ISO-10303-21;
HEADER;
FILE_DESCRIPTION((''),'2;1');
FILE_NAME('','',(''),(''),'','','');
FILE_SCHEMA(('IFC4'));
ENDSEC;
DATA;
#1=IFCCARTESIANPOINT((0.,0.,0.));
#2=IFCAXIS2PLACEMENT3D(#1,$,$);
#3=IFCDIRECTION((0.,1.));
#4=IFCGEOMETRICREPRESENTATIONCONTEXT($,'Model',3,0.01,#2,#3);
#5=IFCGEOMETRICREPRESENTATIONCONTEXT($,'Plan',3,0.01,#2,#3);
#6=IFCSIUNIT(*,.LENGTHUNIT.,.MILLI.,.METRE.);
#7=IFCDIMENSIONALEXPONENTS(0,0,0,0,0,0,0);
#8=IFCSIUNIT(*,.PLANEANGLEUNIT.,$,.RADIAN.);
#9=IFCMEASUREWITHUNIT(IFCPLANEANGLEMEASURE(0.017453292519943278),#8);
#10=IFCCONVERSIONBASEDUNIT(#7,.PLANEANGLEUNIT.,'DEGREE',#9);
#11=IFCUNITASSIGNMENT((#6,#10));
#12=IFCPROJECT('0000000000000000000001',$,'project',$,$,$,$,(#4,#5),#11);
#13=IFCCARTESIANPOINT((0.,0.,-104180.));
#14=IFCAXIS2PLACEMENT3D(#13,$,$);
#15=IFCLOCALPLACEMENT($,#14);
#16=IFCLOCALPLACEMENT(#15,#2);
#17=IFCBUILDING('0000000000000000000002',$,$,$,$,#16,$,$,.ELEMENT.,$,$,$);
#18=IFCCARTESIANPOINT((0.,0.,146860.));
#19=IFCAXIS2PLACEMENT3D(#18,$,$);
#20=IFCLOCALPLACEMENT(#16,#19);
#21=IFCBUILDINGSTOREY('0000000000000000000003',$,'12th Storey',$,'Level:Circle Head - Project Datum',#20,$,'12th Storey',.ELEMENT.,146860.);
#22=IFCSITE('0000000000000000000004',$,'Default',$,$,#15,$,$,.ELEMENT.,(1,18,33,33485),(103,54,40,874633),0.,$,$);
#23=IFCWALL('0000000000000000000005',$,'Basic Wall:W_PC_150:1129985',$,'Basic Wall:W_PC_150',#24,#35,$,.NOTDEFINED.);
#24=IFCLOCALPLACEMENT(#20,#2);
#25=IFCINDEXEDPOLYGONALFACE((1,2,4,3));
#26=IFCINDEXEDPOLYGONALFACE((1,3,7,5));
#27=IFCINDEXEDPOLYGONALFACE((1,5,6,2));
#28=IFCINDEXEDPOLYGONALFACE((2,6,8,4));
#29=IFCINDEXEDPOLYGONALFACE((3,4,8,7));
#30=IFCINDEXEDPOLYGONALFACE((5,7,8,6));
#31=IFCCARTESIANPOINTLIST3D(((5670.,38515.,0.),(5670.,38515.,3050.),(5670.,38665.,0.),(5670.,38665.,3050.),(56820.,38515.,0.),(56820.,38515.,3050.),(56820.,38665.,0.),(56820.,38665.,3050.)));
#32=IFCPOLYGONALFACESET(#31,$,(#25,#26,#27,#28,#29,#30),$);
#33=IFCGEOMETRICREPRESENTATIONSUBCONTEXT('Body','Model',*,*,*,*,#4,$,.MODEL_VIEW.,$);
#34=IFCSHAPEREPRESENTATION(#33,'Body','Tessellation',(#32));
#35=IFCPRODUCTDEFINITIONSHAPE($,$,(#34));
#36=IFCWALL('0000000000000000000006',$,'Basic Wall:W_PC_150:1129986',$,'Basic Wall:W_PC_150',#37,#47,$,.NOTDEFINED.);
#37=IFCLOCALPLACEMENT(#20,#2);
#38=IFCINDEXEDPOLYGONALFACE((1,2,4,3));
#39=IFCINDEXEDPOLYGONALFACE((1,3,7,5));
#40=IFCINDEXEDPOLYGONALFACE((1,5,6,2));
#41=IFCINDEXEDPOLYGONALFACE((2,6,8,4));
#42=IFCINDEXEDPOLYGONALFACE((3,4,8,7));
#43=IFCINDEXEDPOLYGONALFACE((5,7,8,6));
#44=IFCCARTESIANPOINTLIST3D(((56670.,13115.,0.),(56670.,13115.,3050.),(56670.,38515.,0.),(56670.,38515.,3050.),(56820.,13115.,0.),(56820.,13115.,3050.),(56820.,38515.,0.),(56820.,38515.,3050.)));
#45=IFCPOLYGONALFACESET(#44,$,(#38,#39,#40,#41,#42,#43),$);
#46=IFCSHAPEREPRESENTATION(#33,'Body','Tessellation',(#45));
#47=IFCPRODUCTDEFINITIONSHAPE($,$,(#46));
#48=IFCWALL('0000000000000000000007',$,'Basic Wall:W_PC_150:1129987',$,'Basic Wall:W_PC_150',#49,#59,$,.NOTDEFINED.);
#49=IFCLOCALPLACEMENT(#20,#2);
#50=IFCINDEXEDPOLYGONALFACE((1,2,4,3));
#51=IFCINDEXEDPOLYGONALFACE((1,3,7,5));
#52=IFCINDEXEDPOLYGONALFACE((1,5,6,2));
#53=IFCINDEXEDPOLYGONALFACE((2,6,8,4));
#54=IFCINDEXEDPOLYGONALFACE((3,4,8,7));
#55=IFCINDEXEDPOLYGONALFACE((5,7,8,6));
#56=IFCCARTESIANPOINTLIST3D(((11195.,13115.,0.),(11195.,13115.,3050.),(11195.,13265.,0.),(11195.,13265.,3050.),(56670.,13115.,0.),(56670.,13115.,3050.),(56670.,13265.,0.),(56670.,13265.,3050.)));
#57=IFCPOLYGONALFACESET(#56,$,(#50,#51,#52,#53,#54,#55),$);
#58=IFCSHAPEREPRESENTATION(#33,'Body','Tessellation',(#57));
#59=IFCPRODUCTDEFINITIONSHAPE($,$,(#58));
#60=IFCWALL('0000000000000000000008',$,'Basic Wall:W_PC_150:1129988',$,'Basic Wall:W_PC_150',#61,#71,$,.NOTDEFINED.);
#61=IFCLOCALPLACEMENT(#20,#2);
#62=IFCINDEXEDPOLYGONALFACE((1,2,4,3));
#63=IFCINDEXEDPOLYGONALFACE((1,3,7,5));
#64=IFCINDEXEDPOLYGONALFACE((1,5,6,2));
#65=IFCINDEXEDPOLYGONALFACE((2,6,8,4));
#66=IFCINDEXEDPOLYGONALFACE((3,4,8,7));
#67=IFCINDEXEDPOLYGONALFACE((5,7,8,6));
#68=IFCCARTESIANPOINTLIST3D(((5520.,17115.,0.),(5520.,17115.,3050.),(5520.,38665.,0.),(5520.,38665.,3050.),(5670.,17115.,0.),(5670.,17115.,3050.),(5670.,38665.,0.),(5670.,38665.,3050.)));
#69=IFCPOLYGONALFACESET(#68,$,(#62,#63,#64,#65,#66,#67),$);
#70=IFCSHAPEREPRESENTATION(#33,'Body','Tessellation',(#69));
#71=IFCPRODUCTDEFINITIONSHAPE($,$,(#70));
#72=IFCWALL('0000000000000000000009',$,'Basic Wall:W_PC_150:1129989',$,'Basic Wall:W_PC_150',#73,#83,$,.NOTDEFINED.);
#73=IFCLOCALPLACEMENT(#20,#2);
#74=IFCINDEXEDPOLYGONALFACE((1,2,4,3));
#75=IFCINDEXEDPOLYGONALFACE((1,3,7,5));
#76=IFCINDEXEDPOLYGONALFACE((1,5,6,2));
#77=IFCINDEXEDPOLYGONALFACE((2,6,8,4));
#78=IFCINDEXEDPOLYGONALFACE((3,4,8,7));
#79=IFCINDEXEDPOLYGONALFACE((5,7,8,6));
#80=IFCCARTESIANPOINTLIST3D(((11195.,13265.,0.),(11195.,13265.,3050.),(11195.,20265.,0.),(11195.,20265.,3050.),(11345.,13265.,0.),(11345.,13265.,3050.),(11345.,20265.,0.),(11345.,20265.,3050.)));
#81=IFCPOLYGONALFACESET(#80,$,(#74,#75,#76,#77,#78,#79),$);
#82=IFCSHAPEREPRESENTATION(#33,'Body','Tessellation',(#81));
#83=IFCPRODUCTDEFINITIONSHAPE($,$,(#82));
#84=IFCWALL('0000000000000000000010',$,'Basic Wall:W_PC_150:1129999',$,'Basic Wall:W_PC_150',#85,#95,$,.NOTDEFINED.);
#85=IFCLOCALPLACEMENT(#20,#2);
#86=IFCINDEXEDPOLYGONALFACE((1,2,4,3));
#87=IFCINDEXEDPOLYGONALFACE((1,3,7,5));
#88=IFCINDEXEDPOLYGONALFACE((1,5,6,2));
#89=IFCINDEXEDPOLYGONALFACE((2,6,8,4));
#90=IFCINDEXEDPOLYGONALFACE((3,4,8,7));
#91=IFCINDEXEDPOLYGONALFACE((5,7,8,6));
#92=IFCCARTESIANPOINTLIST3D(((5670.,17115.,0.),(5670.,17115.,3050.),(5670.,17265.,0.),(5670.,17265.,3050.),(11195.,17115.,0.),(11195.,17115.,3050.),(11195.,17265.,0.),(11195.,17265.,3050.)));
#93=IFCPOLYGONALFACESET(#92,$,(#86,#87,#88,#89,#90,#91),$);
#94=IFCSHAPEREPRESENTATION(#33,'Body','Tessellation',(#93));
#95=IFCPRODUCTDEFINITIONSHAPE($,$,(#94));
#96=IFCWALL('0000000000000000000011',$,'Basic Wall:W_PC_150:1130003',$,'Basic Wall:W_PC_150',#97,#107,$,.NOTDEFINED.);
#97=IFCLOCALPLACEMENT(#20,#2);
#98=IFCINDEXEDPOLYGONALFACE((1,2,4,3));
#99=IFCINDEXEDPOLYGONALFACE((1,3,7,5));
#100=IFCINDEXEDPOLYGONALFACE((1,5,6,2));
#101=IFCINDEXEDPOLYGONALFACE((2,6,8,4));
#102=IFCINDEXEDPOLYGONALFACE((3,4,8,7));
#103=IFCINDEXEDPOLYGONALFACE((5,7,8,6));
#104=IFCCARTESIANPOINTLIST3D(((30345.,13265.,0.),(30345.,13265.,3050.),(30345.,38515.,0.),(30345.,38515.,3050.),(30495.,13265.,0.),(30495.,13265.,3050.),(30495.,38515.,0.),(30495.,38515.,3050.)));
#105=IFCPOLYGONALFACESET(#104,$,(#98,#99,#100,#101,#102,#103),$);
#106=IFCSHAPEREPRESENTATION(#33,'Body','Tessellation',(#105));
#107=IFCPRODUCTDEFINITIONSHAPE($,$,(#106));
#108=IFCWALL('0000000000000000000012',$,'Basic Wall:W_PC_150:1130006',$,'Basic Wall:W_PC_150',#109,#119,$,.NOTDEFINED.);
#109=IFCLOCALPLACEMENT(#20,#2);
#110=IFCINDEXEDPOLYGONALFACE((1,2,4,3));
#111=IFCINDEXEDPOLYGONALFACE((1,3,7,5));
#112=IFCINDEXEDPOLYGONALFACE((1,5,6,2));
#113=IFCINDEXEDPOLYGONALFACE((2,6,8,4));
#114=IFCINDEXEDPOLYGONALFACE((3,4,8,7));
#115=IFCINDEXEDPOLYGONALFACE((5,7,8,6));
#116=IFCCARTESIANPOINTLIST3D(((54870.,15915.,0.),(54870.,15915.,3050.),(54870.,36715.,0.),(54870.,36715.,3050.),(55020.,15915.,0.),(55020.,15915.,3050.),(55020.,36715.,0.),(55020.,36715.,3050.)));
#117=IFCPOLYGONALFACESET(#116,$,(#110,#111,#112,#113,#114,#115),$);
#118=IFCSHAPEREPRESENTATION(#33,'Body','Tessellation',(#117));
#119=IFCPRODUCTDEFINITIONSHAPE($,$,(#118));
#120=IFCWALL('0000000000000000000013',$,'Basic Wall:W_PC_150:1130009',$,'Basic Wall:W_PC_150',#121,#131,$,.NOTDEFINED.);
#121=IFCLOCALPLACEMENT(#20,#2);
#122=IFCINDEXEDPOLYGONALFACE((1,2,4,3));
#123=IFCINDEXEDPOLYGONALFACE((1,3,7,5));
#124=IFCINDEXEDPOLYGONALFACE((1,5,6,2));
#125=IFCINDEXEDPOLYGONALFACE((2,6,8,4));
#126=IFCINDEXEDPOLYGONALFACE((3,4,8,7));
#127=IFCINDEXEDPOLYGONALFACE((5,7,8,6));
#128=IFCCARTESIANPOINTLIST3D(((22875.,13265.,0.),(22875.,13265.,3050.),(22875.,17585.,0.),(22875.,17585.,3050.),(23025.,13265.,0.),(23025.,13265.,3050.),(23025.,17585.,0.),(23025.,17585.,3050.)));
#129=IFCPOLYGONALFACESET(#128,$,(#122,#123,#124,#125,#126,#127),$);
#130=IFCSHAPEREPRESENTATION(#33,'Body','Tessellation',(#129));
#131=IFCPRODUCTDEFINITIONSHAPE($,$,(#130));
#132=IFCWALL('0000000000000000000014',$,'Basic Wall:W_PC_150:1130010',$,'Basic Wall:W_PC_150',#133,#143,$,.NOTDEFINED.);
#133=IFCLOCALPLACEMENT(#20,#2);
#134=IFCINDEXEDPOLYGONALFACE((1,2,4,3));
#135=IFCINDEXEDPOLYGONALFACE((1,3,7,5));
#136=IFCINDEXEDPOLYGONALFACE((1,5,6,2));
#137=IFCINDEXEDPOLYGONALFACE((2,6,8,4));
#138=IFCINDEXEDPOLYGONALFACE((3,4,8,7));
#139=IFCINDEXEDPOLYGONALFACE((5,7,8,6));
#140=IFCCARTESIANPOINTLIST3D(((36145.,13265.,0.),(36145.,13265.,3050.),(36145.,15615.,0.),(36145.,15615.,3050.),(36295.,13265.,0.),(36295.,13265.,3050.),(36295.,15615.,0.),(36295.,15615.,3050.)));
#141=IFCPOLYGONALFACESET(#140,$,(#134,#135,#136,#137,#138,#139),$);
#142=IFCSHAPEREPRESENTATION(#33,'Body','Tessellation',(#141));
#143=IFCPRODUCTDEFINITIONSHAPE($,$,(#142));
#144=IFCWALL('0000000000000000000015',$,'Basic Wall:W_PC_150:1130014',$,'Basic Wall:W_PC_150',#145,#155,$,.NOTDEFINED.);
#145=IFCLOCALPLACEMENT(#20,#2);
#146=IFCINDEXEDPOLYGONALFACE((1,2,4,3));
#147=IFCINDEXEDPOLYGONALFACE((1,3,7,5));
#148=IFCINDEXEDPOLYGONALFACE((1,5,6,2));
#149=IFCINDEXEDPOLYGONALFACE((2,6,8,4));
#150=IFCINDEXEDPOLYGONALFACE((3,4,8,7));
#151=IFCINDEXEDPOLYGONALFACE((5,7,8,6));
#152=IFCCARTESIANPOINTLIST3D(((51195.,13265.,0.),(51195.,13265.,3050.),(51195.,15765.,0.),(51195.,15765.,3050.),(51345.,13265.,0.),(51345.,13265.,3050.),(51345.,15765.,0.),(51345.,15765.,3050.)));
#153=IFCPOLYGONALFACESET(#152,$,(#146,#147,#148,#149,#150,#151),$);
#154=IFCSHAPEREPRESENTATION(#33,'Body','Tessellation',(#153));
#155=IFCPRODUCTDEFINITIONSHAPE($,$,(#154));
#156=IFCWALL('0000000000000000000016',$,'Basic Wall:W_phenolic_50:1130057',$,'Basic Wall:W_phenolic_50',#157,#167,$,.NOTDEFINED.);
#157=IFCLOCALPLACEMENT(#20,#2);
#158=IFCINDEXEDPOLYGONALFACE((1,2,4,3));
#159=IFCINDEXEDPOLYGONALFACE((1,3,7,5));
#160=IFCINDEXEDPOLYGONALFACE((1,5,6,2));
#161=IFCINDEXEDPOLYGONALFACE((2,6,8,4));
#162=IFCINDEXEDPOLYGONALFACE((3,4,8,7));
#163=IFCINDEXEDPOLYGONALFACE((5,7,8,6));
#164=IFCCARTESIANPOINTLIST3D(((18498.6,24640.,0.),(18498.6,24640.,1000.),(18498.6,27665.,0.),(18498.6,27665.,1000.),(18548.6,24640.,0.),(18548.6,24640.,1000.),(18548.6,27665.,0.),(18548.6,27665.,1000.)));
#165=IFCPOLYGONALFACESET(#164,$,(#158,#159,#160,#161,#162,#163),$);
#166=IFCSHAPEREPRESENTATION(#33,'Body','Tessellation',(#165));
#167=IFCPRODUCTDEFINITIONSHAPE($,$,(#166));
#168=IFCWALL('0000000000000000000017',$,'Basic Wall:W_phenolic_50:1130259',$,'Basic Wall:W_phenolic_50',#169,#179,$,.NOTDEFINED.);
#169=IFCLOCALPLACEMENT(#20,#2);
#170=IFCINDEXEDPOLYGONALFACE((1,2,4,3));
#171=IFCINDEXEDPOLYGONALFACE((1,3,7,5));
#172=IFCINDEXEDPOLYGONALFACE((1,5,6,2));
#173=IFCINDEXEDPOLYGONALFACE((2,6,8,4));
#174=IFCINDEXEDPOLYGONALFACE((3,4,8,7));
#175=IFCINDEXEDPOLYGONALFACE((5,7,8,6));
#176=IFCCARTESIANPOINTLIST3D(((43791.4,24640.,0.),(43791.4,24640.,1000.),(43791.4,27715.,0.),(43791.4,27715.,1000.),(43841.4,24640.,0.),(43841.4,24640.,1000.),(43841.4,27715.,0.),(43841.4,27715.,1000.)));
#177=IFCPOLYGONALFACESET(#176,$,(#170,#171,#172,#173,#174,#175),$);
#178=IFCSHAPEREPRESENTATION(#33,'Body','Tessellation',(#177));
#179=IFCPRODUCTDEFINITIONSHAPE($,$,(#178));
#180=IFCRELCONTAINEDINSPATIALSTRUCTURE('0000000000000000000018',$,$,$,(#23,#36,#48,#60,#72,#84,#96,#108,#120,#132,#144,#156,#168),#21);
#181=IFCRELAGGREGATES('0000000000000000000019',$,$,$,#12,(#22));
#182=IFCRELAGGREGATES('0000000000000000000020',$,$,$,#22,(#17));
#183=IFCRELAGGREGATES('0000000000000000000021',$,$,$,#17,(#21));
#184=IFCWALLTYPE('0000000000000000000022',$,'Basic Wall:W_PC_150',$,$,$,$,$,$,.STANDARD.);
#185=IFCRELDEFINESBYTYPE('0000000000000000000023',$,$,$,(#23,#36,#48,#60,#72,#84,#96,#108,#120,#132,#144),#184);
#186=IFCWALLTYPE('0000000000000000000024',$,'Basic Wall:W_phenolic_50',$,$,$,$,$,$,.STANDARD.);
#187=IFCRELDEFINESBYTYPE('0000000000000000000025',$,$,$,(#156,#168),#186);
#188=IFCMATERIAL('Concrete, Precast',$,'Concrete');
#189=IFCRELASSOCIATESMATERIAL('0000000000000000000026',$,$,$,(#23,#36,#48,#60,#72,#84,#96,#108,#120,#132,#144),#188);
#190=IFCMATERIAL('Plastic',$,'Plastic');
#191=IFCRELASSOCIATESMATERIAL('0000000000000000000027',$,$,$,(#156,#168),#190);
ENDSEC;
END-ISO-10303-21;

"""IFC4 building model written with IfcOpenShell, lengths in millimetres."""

from ifc_helpers import new_model, entity, si_unit, converted_unit, direction, frame, origin, place, context, subcontext, project, spatial, indexed_curve, outline, extrude, material, type_object, element, save


model = new_model("IFC4")

# Units and contexts
model_context = context("Model", 3, precision=0.01, world=origin(), true_north=direction((0.0, 1.0)))
plan_context = context("Plan", 3, precision=0.01, world=origin(), true_north=direction((0.0, 1.0)))
body_context = subcontext(model_context, "Body", "Model", "MODEL_VIEW")
ifc_project = project(units=[si_unit("LENGTHUNIT", "METRE", prefix="MILLI"), converted_unit("PLANEANGLEUNIT", "DEGREE", entity("IfcPlaneAngleMeasure", 0.017453292519943278), si_unit("PLANEANGLEUNIT", "RADIAN"), dimensions=[0, 0, 0, 0, 0, 0, 0])], contexts=[model_context, plan_context])

# Site, building, storey
site_placement = place(None, frame((0.0, 0.0, -104180.0)))
site = spatial("IfcSite", under=ifc_project, at=site_placement, Name="Default", CompositionType="ELEMENT", RefLatitude=(1, 18, 33, 33485), RefLongitude=(103, 54, 40, 874633), RefElevation=0.0)
building_placement = place(site_placement, origin())
building = spatial("IfcBuilding", under=site, at=building_placement, CompositionType="ELEMENT")
storey_placement = place(building_placement, frame((0.0, 0.0, 146860.0)))
storey = spatial("IfcBuildingStorey", under=building, at=storey_placement, Name="12th Storey", ObjectType="Level:Circle Head - Project Datum", LongName="12th Storey", CompositionType="ELEMENT", Elevation=146860.0)

# Shared definitions
ifc_material_1 = material(Name="Concrete, Precast", Category="Concrete")

# Walls
wall_type_1 = type_object("IfcWallType", Name="Basic Wall:W_PC_150", PredefinedType="STANDARD")
wall_1_placement = place(storey_placement, frame((56820.0, 38590.0, 0.0), z_axis=(0.0, 0.0, 1.0), x_axis=(-1.0, 0.0, 0.0)))
element("IfcWall", 1, at=wall_1_placement, inside=storey, type_object=wall_type_1, material=ifc_material_1, Name="Basic Wall:W_PC_150:1129985", ObjectType="Basic Wall:W_PC_150", PredefinedType="NOTDEFINED", context=body_context, shape_type="SweptSolid", body=[
    extrude(outline(indexed_curve([(51150.0, 75.0), (0.0, 75.0), (0.0, -75.0), (51150.0, -75.0), (51150.0, 75.0)], self_intersect=False)), origin(), (0.0, 0.0, 1.0), 3050.0),
])
wall_2_placement = place(storey_placement, frame((56745.0, 13115.0, 0.0), z_axis=(0.0, 0.0, 1.0), x_axis=(0.0, 1.0, 0.0)))
element("IfcWall", 2, at=wall_2_placement, inside=storey, type_object=wall_type_1, material=ifc_material_1, Name="Basic Wall:W_PC_150:1129986", ObjectType="Basic Wall:W_PC_150", PredefinedType="NOTDEFINED", context=body_context, shape_type="SweptSolid", body=[
    extrude(outline(indexed_curve([(25400.0, 75.0), (0.0, 75.0), (0.0, -75.0), (25400.0, -75.0), (25400.0, 75.0)], self_intersect=False)), origin(), (0.0, 0.0, 1.0), 3050.0),
])
wall_3_placement = place(storey_placement, frame((11195.0, 13190.0, 0.0)))
element("IfcWall", 3, at=wall_3_placement, inside=storey, type_object=wall_type_1, material=ifc_material_1, Name="Basic Wall:W_PC_150:1129987", ObjectType="Basic Wall:W_PC_150", PredefinedType="NOTDEFINED", context=body_context, shape_type="SweptSolid", body=[
    extrude(outline(indexed_curve([(45475.0, 75.0), (0.0, 75.0), (0.0, -75.0), (45475.0, -75.0), (45475.0, 75.0)], self_intersect=False)), origin(), (0.0, 0.0, 1.0), 3050.0),
])
wall_4_placement = place(storey_placement, frame((5595.0, 38665.0, 0.0), z_axis=(0.0, 0.0, 1.0), x_axis=(0.0, -1.0, 0.0)))
element("IfcWall", 4, at=wall_4_placement, inside=storey, type_object=wall_type_1, material=ifc_material_1, Name="Basic Wall:W_PC_150:1129988", ObjectType="Basic Wall:W_PC_150", PredefinedType="NOTDEFINED", context=body_context, shape_type="SweptSolid", body=[
    extrude(outline(indexed_curve([(21550.0, 75.0), (0.0, 75.0), (0.0, -75.0), (21550.0, -75.0), (21550.0, 75.0)], self_intersect=False)), origin(), (0.0, 0.0, 1.0), 3050.0),
])
wall_5_placement = place(storey_placement, frame((11270.0, 20265.0, 0.0), z_axis=(0.0, 0.0, 1.0), x_axis=(0.0, -1.0, 0.0)))
element("IfcWall", 5, at=wall_5_placement, inside=storey, type_object=wall_type_1, material=ifc_material_1, Name="Basic Wall:W_PC_150:1129989", ObjectType="Basic Wall:W_PC_150", PredefinedType="NOTDEFINED", context=body_context, shape_type="SweptSolid", body=[
    extrude(outline(indexed_curve([(7000.0, 75.0), (0.0, 75.0), (0.0, -75.0), (7000.0, -75.0), (7000.0, 75.0)], self_intersect=False)), origin(), (0.0, 0.0, 1.0), 3050.0),
])
wall_6_placement = place(storey_placement, frame((5670.0, 17190.0, 0.0)))
element("IfcWall", 6, at=wall_6_placement, inside=storey, type_object=wall_type_1, material=ifc_material_1, Name="Basic Wall:W_PC_150:1129999", ObjectType="Basic Wall:W_PC_150", PredefinedType="NOTDEFINED", context=body_context, shape_type="SweptSolid", body=[
    extrude(outline(indexed_curve([(5525.0, 75.0), (0.0, 75.0), (0.0, -75.0), (5525.0, -75.0), (5525.0, 75.0)], self_intersect=False)), origin(), (0.0, 0.0, 1.0), 3050.0),
])
wall_7_placement = place(storey_placement, frame((30420.0, 13265.0, 0.0), z_axis=(0.0, 0.0, 1.0), x_axis=(0.0, 1.0, 0.0)))
element("IfcWall", 7, at=wall_7_placement, inside=storey, type_object=wall_type_1, material=ifc_material_1, Name="Basic Wall:W_PC_150:1130003", ObjectType="Basic Wall:W_PC_150", PredefinedType="NOTDEFINED", context=body_context, shape_type="SweptSolid", body=[
    extrude(outline(indexed_curve([(25250.0, 75.0), (0.0, 75.0), (0.0, -75.0), (25250.0, -75.0), (25250.0, 75.0)], self_intersect=False)), origin(), (0.0, 0.0, 1.0), 3050.0),
])
wall_8_placement = place(storey_placement, frame((54945.0, 15915.0, 0.0), z_axis=(0.0, 0.0, 1.0), x_axis=(0.0, 1.0, 0.0)))
element("IfcWall", 8, at=wall_8_placement, inside=storey, type_object=wall_type_1, material=ifc_material_1, Name="Basic Wall:W_PC_150:1130006", ObjectType="Basic Wall:W_PC_150", PredefinedType="NOTDEFINED", context=body_context, shape_type="SweptSolid", body=[
    extrude(outline(indexed_curve([(20800.0, 75.0), (0.0, 75.0), (0.0, -75.0), (20800.0, -75.0), (20800.0, 75.0)], self_intersect=False)), origin(), (0.0, 0.0, 1.0), 3050.0),
])
wall_9_placement = place(storey_placement, frame((22950.0, 13265.0, 0.0), z_axis=(0.0, 0.0, 1.0), x_axis=(0.0, 1.0, 0.0)))
element("IfcWall", 9, at=wall_9_placement, inside=storey, type_object=wall_type_1, material=ifc_material_1, Name="Basic Wall:W_PC_150:1130009", ObjectType="Basic Wall:W_PC_150", PredefinedType="NOTDEFINED", context=body_context, shape_type="SweptSolid", body=[
    extrude(outline(indexed_curve([(4320.0, 75.0), (0.0, 75.0), (0.0, -75.0), (4320.0, -75.0), (4320.0, 75.0)], self_intersect=False)), origin(), (0.0, 0.0, 1.0), 3050.0),
])
wall_10_placement = place(storey_placement, frame((36220.0, 13265.0, 0.0), z_axis=(0.0, 0.0, 1.0), x_axis=(0.0, 1.0, 0.0)))
element("IfcWall", 10, at=wall_10_placement, inside=storey, type_object=wall_type_1, material=ifc_material_1, Name="Basic Wall:W_PC_150:1130010", ObjectType="Basic Wall:W_PC_150", PredefinedType="NOTDEFINED", context=body_context, shape_type="SweptSolid", body=[
    extrude(outline(indexed_curve([(2350.0, 75.0), (0.0, 75.0), (0.0, -75.0), (2350.0, -75.0), (2350.0, 75.0)], self_intersect=False)), origin(), (0.0, 0.0, 1.0), 3050.0),
])
wall_11_placement = place(storey_placement, frame((51270.0, 13265.0, 0.0), z_axis=(0.0, 0.0, 1.0), x_axis=(0.0, 1.0, 0.0)))
element("IfcWall", 11, at=wall_11_placement, inside=storey, type_object=wall_type_1, material=ifc_material_1, Name="Basic Wall:W_PC_150:1130014", ObjectType="Basic Wall:W_PC_150", PredefinedType="NOTDEFINED", context=body_context, shape_type="SweptSolid", body=[
    extrude(outline(indexed_curve([(2500.0, 75.0), (0.0, 75.0), (0.0, -75.0), (2500.0, -75.0), (2500.0, 75.0)], self_intersect=False)), origin(), (0.0, 0.0, 1.0), 3050.0),
])
ifc_material_2 = material(Name="Plastic", Category="Plastic")
wall_type_2 = type_object("IfcWallType", Name="Basic Wall:W_phenolic_50", PredefinedType="STANDARD")
wall_12_placement = place(storey_placement, frame((18523.6, 24640.0, 0.0), z_axis=(0.0, 0.0, 1.0), x_axis=(0.0, 1.0, 0.0)))
element("IfcWall", 12, at=wall_12_placement, inside=storey, type_object=wall_type_2, material=ifc_material_2, Name="Basic Wall:W_phenolic_50:1130057", ObjectType="Basic Wall:W_phenolic_50", PredefinedType="NOTDEFINED", context=body_context, shape_type="SweptSolid", body=[
    extrude(outline(indexed_curve([(3025.0, 25.0), (0.0, 25.0), (0.0, -25.0), (3025.0, -25.0), (3025.0, 25.0)], self_intersect=False)), origin(), (0.0, 0.0, 1.0), 1000.0),
])
wall_13_placement = place(storey_placement, frame((43816.4, 24640.0, 0.0), z_axis=(0.0, 0.0, 1.0), x_axis=(0.0, 1.0, 0.0)))
element("IfcWall", 13, at=wall_13_placement, inside=storey, type_object=wall_type_2, material=ifc_material_2, Name="Basic Wall:W_phenolic_50:1130259", ObjectType="Basic Wall:W_phenolic_50", PredefinedType="NOTDEFINED", context=body_context, shape_type="SweptSolid", body=[
    extrude(outline(indexed_curve([(3075.0, 25.0), (0.0, 25.0), (0.0, -25.0), (3075.0, -25.0), (3075.0, 25.0)], self_intersect=False)), origin(), (0.0, 0.0, 1.0), 1000.0),
])

save(model, "model.ifc")
